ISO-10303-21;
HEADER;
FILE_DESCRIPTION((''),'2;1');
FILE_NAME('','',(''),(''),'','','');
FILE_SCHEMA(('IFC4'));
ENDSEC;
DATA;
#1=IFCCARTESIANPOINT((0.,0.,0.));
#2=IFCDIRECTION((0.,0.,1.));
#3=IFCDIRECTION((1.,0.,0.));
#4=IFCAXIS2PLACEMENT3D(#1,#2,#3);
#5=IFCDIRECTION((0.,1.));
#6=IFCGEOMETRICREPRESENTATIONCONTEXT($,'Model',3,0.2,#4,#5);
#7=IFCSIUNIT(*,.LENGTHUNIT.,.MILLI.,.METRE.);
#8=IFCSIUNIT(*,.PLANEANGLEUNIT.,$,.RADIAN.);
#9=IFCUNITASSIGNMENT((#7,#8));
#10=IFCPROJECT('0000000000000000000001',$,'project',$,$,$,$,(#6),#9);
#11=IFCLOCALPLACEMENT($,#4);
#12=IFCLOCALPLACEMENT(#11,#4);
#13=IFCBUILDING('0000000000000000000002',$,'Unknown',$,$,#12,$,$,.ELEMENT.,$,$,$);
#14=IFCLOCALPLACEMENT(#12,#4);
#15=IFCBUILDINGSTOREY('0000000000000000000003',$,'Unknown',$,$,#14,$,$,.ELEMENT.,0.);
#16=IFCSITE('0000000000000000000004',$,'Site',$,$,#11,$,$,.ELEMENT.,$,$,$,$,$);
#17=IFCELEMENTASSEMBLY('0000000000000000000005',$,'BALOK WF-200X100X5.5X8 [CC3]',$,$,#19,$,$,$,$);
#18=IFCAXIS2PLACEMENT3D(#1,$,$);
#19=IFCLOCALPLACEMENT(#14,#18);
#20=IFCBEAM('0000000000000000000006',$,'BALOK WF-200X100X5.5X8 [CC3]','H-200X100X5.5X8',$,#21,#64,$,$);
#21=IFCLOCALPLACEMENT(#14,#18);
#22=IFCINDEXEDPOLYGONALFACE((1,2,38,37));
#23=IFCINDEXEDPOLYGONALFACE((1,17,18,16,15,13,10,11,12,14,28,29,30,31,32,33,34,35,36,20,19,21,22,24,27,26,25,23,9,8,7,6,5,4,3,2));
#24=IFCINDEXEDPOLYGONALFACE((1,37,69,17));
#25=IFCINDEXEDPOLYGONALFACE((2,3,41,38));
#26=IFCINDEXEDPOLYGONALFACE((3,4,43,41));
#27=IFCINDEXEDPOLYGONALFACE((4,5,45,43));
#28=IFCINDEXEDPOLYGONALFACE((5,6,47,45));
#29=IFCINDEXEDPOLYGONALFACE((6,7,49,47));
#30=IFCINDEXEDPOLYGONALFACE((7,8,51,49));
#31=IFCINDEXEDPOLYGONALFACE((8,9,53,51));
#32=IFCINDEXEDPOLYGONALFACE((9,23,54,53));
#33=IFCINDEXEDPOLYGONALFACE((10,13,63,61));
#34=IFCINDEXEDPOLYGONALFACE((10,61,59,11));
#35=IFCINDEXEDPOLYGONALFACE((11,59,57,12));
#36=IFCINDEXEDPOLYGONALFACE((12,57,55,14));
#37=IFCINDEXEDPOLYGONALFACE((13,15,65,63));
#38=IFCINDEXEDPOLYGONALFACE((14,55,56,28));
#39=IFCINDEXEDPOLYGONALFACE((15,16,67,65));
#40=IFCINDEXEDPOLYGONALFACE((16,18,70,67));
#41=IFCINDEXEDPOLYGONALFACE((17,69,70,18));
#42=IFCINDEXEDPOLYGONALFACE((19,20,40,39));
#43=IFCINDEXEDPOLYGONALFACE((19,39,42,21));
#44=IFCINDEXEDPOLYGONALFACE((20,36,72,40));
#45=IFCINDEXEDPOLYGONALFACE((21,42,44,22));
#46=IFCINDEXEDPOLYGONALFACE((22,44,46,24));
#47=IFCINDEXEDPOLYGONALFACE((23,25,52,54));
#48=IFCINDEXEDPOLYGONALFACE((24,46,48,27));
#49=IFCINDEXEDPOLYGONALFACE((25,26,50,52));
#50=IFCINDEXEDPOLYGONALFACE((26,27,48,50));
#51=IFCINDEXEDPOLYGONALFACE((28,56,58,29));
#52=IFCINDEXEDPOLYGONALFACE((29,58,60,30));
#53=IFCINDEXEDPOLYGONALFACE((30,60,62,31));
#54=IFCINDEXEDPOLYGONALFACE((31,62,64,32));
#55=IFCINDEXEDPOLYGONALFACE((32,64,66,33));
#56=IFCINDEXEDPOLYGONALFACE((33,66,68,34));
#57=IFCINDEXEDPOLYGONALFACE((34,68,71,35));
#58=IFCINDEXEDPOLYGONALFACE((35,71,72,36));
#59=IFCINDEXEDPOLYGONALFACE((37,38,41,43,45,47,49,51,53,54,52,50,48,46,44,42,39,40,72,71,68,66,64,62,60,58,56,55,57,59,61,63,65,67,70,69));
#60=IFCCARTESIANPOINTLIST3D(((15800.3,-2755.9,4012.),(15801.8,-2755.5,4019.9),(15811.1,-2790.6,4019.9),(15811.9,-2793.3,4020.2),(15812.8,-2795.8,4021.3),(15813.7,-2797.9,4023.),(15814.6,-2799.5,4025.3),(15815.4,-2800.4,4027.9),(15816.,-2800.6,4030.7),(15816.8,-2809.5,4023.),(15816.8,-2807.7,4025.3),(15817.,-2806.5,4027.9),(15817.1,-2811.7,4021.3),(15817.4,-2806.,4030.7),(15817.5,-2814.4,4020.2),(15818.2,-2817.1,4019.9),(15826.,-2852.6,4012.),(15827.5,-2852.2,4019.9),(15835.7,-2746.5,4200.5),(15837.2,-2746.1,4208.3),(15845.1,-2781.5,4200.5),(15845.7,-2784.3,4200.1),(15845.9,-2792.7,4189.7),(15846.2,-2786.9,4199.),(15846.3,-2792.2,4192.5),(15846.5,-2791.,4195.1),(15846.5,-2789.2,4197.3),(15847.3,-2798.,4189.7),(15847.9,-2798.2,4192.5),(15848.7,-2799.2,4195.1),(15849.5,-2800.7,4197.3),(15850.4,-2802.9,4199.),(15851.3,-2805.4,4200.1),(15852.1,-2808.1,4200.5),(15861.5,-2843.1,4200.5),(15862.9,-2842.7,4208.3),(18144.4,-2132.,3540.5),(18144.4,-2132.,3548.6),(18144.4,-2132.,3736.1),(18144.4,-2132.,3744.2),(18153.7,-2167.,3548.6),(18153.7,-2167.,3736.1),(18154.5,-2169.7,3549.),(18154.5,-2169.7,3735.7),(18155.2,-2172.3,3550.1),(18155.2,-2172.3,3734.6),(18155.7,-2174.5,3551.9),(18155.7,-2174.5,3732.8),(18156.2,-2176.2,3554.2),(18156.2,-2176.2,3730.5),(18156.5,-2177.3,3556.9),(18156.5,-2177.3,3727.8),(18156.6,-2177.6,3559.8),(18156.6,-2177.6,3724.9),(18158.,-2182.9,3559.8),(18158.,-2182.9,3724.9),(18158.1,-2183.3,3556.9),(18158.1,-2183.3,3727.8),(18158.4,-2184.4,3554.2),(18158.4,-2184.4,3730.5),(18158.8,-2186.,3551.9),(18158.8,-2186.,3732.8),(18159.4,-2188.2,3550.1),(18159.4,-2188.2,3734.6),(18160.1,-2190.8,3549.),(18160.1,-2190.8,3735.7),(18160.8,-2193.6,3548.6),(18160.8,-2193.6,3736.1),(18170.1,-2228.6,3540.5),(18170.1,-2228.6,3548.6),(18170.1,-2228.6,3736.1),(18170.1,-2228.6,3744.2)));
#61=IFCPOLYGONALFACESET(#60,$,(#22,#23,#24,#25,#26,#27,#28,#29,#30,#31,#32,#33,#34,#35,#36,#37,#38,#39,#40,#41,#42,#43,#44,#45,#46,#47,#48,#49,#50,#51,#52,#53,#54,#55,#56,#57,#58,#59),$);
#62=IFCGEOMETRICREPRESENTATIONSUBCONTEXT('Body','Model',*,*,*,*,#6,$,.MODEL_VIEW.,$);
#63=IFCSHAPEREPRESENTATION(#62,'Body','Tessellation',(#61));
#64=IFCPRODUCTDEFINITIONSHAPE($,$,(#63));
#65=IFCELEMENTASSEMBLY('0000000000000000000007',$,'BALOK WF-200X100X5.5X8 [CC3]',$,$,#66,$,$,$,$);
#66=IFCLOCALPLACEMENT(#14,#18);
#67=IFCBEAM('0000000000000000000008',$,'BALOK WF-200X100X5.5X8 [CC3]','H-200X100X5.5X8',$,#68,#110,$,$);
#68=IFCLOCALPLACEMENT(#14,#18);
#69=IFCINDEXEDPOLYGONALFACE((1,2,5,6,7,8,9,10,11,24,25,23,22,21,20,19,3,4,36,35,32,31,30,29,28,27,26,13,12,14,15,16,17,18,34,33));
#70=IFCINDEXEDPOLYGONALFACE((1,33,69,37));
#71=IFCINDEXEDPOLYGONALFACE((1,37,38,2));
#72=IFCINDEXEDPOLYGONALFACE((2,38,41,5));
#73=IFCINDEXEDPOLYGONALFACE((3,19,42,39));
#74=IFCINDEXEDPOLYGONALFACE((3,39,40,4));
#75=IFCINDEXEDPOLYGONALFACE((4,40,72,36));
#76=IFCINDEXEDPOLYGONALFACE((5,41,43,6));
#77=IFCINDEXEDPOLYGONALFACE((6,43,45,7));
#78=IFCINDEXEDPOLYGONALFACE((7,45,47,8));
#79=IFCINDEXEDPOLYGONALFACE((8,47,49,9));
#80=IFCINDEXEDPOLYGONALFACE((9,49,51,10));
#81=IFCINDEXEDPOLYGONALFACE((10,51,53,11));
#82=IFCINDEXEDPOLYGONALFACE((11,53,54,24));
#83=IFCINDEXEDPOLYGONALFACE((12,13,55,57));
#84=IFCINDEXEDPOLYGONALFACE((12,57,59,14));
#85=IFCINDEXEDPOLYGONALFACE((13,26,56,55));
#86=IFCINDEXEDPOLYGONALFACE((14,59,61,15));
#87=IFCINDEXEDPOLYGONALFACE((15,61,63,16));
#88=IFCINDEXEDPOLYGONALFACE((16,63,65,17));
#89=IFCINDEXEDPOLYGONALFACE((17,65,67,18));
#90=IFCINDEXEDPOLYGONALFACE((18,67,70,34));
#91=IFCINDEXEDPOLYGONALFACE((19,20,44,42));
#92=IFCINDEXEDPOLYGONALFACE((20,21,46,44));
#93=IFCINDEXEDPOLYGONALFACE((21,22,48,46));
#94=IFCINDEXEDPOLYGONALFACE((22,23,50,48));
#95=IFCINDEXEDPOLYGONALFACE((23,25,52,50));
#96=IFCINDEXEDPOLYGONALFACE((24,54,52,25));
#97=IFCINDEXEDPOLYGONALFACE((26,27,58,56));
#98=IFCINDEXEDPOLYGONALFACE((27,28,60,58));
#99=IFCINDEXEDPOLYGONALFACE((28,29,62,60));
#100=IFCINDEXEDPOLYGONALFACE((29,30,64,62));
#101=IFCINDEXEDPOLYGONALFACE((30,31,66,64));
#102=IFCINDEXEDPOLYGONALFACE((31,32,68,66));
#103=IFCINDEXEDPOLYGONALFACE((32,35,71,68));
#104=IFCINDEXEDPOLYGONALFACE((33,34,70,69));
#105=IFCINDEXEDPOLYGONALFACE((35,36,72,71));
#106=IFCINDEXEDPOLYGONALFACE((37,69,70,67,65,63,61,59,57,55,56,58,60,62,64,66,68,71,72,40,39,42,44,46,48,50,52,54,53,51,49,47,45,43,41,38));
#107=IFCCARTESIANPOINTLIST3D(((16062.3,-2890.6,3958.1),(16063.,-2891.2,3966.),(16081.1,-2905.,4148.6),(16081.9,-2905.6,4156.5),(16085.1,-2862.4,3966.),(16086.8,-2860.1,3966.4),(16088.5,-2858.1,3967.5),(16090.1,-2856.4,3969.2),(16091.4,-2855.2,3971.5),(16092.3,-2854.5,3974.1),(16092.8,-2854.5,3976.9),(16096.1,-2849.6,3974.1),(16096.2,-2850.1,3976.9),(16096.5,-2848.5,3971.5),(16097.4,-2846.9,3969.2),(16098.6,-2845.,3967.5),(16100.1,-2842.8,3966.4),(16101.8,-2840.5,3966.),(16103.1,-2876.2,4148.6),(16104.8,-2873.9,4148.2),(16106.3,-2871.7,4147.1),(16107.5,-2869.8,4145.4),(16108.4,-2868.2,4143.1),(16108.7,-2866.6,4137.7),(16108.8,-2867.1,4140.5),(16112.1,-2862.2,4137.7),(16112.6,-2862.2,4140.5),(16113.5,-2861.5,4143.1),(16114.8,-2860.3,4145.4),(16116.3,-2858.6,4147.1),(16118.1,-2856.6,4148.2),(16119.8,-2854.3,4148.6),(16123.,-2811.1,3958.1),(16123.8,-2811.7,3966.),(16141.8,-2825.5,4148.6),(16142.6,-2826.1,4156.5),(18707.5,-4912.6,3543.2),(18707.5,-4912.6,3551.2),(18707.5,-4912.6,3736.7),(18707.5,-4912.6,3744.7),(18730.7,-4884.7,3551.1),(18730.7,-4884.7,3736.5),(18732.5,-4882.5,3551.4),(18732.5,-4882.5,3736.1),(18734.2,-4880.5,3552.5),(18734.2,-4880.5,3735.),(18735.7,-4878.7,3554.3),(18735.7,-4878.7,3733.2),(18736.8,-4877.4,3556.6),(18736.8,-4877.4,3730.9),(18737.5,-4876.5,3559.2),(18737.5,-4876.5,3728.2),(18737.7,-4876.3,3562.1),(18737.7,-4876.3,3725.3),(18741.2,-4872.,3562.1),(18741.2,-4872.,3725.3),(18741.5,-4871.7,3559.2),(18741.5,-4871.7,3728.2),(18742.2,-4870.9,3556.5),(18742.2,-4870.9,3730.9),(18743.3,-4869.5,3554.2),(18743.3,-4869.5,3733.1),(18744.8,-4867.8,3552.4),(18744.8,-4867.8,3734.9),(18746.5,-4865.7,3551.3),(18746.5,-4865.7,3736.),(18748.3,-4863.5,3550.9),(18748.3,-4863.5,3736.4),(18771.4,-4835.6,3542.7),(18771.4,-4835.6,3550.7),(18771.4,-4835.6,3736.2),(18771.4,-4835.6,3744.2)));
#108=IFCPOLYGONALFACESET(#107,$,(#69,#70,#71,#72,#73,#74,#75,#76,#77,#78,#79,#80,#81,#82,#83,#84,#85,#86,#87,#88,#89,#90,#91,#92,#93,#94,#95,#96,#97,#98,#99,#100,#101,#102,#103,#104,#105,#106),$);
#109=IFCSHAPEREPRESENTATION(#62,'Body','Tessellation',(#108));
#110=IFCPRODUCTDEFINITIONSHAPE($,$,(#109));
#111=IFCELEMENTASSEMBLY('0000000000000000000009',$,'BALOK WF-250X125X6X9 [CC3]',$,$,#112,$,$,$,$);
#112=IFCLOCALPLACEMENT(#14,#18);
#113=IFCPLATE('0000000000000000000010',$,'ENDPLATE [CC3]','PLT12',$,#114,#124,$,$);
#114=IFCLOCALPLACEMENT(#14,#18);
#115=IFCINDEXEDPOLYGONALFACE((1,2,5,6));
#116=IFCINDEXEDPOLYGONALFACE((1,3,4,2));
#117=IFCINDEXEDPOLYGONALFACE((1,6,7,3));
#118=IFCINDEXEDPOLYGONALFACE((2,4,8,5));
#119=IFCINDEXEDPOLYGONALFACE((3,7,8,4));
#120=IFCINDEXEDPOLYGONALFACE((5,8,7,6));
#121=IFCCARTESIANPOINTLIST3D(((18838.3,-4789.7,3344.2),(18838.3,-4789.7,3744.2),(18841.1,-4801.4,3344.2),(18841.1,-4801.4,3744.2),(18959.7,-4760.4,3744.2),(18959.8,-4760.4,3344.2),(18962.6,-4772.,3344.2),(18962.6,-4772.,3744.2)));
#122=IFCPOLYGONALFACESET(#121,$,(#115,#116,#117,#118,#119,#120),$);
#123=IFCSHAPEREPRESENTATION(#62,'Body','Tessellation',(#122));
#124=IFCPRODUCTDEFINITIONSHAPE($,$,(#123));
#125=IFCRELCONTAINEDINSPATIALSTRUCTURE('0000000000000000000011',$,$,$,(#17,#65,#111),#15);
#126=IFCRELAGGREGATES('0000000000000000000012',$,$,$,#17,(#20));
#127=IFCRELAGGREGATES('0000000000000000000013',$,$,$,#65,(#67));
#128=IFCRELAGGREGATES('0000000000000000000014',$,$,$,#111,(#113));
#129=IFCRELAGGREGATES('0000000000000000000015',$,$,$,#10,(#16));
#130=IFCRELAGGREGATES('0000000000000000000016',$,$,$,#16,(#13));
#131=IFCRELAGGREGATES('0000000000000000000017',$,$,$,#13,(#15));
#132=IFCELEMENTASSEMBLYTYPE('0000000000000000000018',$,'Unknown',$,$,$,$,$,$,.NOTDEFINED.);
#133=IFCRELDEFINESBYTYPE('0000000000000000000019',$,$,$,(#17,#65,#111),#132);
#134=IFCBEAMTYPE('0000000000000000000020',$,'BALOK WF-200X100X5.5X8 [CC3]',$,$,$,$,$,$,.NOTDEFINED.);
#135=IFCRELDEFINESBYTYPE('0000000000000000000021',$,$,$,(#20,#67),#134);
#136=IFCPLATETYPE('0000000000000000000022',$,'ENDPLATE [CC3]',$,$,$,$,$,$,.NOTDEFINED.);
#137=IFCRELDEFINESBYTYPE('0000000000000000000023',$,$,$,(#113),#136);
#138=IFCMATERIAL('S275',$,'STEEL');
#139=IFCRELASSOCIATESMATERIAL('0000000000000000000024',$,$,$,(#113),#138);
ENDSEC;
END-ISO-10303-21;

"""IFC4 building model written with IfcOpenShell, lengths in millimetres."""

from ifc_helpers import new_model, si_unit, direction, frame, origin_with_axes, origin_2d_with_axis, place, context, subcontext, project, spatial, line, indexed_curve, i_section, outline, extrude, clip, halfspace, material, material_profile, profile_set, profile_usage, type_object, element, aggregate, save


model = new_model("IFC4")

# Units and contexts
model_context = context("Model", 3, precision=0.2, world=origin_with_axes(), true_north=direction((0.0, 1.0)))
body_context = subcontext(model_context, "Body", "Model", "MODEL_VIEW")
ifc_project = project(units=[si_unit("LENGTHUNIT", "METRE", prefix="MILLI"), si_unit("PLANEANGLEUNIT", "RADIAN")], contexts=[model_context])

# Site, building, storey
site_placement = place(None, origin_with_axes())
site = spatial("IfcSite", under=ifc_project, at=site_placement, Name="Site", CompositionType="ELEMENT")
building_placement = place(site_placement, origin_with_axes())
building = spatial("IfcBuilding", under=site, at=building_placement, Name="Unknown", CompositionType="ELEMENT")
storey_placement = place(building_placement, origin_with_axes())
storey = spatial("IfcBuildingStorey", under=building, at=storey_placement, Name="Unknown", CompositionType="ELEMENT", Elevation=0.0)

# Element assemblies, beams
element_assembly_type = type_object("IfcElementAssemblyType", Name="Unknown", PredefinedType="NOTDEFINED")
assembly_1_placement = place(storey_placement, frame((18179.4, -2174.4, 3637.9), z_axis=(-0.257229, 0.96635, 0.0), x_axis=(-0.948596, -0.252503, 0.190809)))
assembly_1 = element("IfcElementAssembly", 1, at=assembly_1_placement, inside=storey, type_object=element_assembly_type, Name="BALOK WF-200X100X5.5X8 [CC3]")
beam_type = type_object("IfcBeamType", Name="BALOK WF-200X100X5.5X8 [CC3]", PredefinedType="NOTDEFINED")
beam_1_placement = place(assembly_1_placement, origin_with_axes())
beam_1 = element("IfcBeam", 2, at=beam_1_placement, type_object=beam_type, Name="BALOK WF-200X100X5.5X8 [CC3]", Description="H-200X100X5.5X8", context=body_context, shape_type="Clipping", body=[
    clip(clip(extrude(i_section(OverallWidth=100.0, OverallDepth=200.0, WebThickness=5.5, FlangeThickness=8.0, FilletRadius=11.0, FlangeEdgeRadius=0.0, FlangeSlope=0.0, at=origin_2d_with_axis()), frame((0.0, 0.0, 0.0), z_axis=(-1.0, 0.0, 0.0), x_axis=(0.0, 0.0, 1.0)), (0.0, 0.0, -1.0), 2475.0), halfspace(frame((-7.0, -145.2, -62.5), z_axis=(-0.98162, 0.190845, 0.000003), x_axis=(0.000003, -0.000001, 1.0)), False)), halfspace(frame((3.9, -100.0, -50.0), z_axis=(-0.981627, 0.190809, 0.000001), x_axis=(0.000001, 0.0, 1.0)), False)),
])
assembly_2_placement = place(storey_placement, frame((18773.0, -4899.7, 3638.5), z_axis=(0.607303, 0.79447, 0.0), x_axis=(-0.788374, 0.602643, 0.123645)))
assembly_2 = element("IfcElementAssembly", 3, at=assembly_2_placement, inside=storey, type_object=element_assembly_type, Name="BALOK WF-200X100X5.5X8 [CC3]")
beam_2_placement = place(assembly_2_placement, origin_with_axes())
beam_2 = element("IfcBeam", 4, at=beam_2_placement, type_object=beam_type, Name="BALOK WF-200X100X5.5X8 [CC3]", Description="H-200X100X5.5X8", context=body_context, shape_type="Clipping", body=[
    clip(clip(extrude(i_section(OverallWidth=100.0, OverallDepth=200.0, WebThickness=5.5, FlangeThickness=8.0, FilletRadius=11.0, FlangeEdgeRadius=0.0, FlangeSlope=0.0, at=origin_2d_with_axis()), frame((0.0, 0.0, 0.0), z_axis=(-1.0, 0.0, 0.0), x_axis=(0.0, 0.0, 1.0)), (0.0, 0.0, -1.0), 3387.4), halfspace(frame((30.0, -100.0, -50.0), z_axis=(-0.991531, 0.123546, -0.040025), x_axis=(-0.040334, 0.0, 0.999186)), False)), halfspace(frame((32.0, -100.0, -50.0), z_axis=(-0.991531, 0.123546, -0.040025), x_axis=(-0.040334, 0.0, 0.999186)), False)),
])

aggregate(assembly_1, [beam_1])

# Shared definitions
ifc_material_1 = material(Name="S275", Category="STEEL")

# Element assembly, plate
assembly_3_placement = place(storey_placement, frame((17628.6, 487.2, 3619.2), z_axis=(-0.972076, -0.234666, 0.0), x_axis=(0.234666, -0.972076, 0.0)))
assembly_3 = element("IfcElementAssembly", 5, at=assembly_3_placement, inside=storey, type_object=element_assembly_type, Name="BALOK WF-250X125X6X9 [CC3]")
ifc_material_profile_1 = material_profile(ifc_material_1, outline(indexed_curve([(0.0, 0.0), (124.9, 0.0), (124.9, 400.0), (-0.1, 400.0)], segments=[line(1, 2, 3, 4, 1)])), Name="PLT12")
ifc_profile_set_1 = profile_set([ifc_material_profile_1])
ifc_profile_usage_1 = profile_usage(ifc_profile_set_1, cardinal=5)
plate_type_1 = type_object("IfcPlateType", Name="ENDPLATE [CC3]", PredefinedType="NOTDEFINED")
plate_1_placement = place(assembly_3_placement, frame((5419.5, 125.0, -62.5), z_axis=(1.0, 0.000041, 0.0), x_axis=(0.0, 0.0, 1.0)))
plate_1 = element("IfcPlate", 6, at=plate_1_placement, type_object=plate_type_1, material=ifc_profile_usage_1, Name="ENDPLATE [CC3]", Description="PLT12", context=body_context, shape_type="SolidModel", body=[
    extrude(outline(indexed_curve([(0.0, 0.0), (124.9, 0.0), (124.9, 400.0), (-0.1, 400.0)], segments=[line(1, 2, 3, 4, 1)])), frame((0.0, 0.0, 6.0), z_axis=(0.0, 0.0, 1.0), x_axis=(1.0, 0.0, 0.0)), (0.0, 0.0, -1.0), 12.0),
])

aggregate(assembly_2, [beam_2])

aggregate(assembly_3, [plate_1])

save(model, "model.ifc")
